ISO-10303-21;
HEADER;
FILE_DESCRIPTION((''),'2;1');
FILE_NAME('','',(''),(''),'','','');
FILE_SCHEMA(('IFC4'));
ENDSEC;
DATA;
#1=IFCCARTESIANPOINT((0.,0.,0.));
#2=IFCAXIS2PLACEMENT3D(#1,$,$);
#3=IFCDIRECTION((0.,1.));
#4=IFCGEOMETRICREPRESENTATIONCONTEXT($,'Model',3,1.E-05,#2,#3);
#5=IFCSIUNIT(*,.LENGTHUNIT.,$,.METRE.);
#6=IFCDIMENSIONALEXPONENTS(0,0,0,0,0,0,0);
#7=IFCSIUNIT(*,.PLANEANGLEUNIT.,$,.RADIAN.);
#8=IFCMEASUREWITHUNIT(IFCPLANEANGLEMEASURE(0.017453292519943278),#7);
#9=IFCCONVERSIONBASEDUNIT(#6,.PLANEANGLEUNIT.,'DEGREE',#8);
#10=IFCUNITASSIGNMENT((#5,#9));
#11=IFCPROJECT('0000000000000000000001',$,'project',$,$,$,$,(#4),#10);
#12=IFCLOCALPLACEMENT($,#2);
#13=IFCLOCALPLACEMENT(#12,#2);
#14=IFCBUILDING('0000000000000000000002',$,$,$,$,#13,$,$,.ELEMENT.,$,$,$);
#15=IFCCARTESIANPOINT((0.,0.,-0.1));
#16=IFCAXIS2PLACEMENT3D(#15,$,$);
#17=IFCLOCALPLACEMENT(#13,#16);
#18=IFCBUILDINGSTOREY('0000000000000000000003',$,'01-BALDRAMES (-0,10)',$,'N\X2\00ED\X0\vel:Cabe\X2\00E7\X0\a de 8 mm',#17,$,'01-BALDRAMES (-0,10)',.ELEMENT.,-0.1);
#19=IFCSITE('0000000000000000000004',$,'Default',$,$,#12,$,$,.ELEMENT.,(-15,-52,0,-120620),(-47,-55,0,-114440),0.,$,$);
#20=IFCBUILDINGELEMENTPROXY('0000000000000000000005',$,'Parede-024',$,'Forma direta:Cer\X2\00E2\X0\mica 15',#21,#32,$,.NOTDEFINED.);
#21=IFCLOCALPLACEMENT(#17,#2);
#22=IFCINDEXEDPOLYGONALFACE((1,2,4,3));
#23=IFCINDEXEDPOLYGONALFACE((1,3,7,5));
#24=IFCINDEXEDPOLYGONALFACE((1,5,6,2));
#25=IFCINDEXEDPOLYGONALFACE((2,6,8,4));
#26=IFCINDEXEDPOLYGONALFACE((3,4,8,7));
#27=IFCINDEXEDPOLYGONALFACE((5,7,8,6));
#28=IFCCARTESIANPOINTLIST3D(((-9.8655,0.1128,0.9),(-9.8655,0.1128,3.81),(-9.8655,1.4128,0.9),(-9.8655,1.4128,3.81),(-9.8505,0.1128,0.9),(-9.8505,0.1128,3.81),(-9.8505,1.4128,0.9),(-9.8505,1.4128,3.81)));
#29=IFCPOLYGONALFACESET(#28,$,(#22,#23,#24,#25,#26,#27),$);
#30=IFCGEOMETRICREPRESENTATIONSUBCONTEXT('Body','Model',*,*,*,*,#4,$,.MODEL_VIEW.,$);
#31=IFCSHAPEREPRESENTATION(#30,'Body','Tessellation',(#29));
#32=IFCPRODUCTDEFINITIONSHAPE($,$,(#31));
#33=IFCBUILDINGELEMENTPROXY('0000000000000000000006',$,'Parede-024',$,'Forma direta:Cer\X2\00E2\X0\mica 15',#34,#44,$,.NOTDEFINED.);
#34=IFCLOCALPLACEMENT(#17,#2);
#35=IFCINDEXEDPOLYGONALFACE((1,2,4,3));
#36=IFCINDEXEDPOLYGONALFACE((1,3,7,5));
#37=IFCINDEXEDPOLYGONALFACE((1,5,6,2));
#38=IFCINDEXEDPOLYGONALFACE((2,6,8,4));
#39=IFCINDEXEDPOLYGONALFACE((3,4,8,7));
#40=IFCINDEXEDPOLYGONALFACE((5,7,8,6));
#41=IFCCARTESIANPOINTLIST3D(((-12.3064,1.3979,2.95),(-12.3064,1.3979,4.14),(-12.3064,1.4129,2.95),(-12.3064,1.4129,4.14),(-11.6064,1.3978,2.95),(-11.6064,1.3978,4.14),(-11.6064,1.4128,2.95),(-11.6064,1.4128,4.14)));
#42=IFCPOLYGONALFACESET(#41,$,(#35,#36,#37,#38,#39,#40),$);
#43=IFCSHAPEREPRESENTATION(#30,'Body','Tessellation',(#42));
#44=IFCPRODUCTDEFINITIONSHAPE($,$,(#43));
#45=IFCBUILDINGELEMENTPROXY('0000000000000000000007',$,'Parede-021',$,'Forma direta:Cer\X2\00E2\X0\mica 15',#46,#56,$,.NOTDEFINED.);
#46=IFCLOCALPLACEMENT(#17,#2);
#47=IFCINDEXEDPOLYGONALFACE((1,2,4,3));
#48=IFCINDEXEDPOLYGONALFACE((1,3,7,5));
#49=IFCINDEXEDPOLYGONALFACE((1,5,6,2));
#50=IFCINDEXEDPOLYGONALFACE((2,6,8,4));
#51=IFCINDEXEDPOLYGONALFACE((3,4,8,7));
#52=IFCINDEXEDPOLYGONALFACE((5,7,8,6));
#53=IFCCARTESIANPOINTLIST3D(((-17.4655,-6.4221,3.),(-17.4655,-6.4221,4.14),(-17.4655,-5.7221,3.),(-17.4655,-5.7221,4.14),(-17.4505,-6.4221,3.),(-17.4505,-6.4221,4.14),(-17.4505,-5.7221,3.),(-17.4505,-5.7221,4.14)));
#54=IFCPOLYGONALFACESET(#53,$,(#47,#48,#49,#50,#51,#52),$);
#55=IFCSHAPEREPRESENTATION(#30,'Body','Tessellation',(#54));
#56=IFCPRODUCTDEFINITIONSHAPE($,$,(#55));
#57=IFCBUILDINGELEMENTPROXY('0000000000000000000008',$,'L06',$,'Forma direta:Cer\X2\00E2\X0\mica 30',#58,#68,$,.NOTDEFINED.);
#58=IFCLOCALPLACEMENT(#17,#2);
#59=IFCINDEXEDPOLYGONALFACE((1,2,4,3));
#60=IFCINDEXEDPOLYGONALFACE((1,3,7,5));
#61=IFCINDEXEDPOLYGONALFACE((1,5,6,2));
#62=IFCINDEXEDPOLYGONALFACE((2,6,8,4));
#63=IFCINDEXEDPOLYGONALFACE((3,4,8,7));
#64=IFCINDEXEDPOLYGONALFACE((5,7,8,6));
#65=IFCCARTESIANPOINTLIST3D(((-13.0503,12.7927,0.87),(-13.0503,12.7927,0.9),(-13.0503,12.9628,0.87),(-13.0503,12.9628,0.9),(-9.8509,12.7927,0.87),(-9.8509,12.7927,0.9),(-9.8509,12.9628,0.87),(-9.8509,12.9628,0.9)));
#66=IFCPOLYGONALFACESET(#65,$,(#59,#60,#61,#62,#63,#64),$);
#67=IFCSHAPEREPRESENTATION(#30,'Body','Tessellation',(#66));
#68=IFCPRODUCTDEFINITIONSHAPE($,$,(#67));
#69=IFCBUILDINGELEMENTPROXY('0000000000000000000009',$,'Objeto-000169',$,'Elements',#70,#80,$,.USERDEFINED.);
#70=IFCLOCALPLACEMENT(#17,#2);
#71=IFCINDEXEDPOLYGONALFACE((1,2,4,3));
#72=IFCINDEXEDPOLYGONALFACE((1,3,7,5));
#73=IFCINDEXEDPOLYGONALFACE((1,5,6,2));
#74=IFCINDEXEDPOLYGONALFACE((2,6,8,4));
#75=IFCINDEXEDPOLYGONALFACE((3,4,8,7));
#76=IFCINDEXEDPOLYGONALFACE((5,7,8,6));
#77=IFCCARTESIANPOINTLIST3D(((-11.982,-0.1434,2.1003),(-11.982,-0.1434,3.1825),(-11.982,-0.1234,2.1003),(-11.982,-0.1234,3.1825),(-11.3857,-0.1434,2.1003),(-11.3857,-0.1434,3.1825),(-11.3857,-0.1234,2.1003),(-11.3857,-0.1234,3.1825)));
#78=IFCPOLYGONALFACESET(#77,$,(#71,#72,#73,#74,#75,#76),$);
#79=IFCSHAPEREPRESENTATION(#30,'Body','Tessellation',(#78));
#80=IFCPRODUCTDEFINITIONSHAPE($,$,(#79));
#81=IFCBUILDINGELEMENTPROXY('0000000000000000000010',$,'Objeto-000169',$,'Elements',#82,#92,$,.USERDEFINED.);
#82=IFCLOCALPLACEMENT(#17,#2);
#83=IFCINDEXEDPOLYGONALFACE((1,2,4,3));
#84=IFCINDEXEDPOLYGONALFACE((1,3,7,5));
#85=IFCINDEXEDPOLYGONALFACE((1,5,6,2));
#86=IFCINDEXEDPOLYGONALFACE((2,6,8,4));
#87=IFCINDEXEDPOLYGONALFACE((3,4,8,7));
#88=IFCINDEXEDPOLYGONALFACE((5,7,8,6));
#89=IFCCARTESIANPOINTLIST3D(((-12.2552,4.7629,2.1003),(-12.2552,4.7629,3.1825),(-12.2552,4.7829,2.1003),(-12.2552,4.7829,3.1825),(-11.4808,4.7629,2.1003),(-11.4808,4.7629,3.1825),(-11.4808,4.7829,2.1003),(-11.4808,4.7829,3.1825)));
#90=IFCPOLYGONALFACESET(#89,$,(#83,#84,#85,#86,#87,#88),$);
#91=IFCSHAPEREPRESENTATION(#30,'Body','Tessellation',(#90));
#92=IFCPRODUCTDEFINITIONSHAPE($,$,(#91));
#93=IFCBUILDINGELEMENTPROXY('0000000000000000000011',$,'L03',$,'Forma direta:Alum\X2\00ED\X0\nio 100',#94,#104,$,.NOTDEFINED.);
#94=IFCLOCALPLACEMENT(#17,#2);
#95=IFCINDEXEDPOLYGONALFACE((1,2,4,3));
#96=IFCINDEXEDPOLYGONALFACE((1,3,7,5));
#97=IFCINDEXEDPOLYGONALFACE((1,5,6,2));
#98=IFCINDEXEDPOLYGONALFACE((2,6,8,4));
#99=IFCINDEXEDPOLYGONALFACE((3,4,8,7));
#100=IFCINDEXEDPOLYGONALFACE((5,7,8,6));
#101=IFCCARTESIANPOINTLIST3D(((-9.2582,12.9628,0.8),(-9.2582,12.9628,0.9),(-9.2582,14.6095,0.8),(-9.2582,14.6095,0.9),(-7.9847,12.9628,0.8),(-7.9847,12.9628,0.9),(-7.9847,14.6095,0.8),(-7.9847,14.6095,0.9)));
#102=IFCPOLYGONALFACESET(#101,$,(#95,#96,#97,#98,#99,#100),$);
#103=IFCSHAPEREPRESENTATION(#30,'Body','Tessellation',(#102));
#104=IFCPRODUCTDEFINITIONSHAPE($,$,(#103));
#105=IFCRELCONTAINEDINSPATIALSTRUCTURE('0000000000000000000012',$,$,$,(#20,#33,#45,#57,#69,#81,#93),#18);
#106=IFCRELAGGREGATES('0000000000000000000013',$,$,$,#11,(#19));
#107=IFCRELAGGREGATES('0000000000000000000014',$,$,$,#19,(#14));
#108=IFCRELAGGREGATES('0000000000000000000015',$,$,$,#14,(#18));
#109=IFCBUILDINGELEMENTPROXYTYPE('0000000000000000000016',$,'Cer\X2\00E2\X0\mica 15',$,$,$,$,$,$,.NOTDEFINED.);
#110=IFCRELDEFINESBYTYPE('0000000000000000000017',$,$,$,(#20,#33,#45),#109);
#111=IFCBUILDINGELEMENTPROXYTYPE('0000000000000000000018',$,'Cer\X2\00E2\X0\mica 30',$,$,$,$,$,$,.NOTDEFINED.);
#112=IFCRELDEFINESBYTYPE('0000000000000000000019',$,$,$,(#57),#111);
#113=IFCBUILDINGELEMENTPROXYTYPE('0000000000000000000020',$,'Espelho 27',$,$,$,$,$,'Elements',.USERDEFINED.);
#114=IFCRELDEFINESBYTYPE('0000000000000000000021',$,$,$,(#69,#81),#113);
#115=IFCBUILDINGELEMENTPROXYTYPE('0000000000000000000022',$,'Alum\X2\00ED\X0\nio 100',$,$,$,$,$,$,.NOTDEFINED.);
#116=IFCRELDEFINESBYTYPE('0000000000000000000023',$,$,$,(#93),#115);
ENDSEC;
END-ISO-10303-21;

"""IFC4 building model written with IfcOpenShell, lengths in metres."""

from ifc_helpers import new_model, entity, si_unit, converted_unit, direction, frame, origin, place, context, subcontext, project, spatial, indexed_curve, outline, extrude, type_object, element, save


model = new_model("IFC4")

# Units and contexts
model_context = context("Model", 3, precision=1e-05, world=origin(), true_north=direction((0.0, 1.0)))
body_context = subcontext(model_context, "Body", "Model", "MODEL_VIEW")
ifc_project = project(units=[si_unit("LENGTHUNIT", "METRE"), converted_unit("PLANEANGLEUNIT", "DEGREE", entity("IfcPlaneAngleMeasure", 0.017453292519943278), si_unit("PLANEANGLEUNIT", "RADIAN"), dimensions=[0, 0, 0, 0, 0, 0, 0])], contexts=[model_context])

# Site, building, storey
site_placement = place(None, origin())
site = spatial("IfcSite", under=ifc_project, at=site_placement, Name="Default", CompositionType="ELEMENT", RefLatitude=(-15, -52, 0, -120620), RefLongitude=(-47, -55, 0, -114440), RefElevation=0.0)
building_placement = place(site_placement, origin())
building = spatial("IfcBuilding", under=site, at=building_placement, CompositionType="ELEMENT")
storey_placement = place(building_placement, frame((0.0, 0.0, -0.1)))
storey = spatial("IfcBuildingStorey", under=building, at=storey_placement, Name="01-BALDRAMES (-0,10)", ObjectType="Nível:Cabeça de 8 mm", LongName="01-BALDRAMES (-0,10)", CompositionType="ELEMENT", Elevation=-0.1)

# Building element proxies
building_element_proxy_type_1 = type_object("IfcBuildingElementProxyType", Name="Cerâmica 15", PredefinedType="NOTDEFINED")
proxy_1_placement = place(storey_placement, origin())
element("IfcBuildingElementProxy", 1, at=proxy_1_placement, inside=storey, type_object=building_element_proxy_type_1, Name="Parede-024", ObjectType="Forma direta:Cerâmica 15", PredefinedType="NOTDEFINED", context=body_context, shape_type="SweptSolid", body=[
    extrude(outline(indexed_curve([(-0.0075, -0.65), (0.0075, -0.65), (0.0075, 0.65), (-0.0075, 0.65), (-0.0075, -0.65)], self_intersect=False)), frame((-9.858, 0.7628, 0.9), z_axis=(0.0, 0.0, 1.0), x_axis=(-1.0, 0.000013, 0.0)), (0.0, 0.0, 1.0), 2.91),
])
proxy_2_placement = place(storey_placement, origin())
element("IfcBuildingElementProxy", 2, at=proxy_2_placement, inside=storey, type_object=building_element_proxy_type_1, Name="Parede-024", ObjectType="Forma direta:Cerâmica 15", PredefinedType="NOTDEFINED", context=body_context, shape_type="SweptSolid", body=[
    extrude(outline(indexed_curve([(-0.0075, -0.35), (0.0075, -0.35), (0.0075, 0.35), (-0.0075, 0.35), (-0.0075, -0.35)], self_intersect=False)), frame((-11.9564, 1.4054, 2.95), z_axis=(0.0, 0.0, 1.0), x_axis=(0.000013, 1.0, 0.0)), (0.0, 0.0, 1.0), 1.19),
])
proxy_3_placement = place(storey_placement, origin())
element("IfcBuildingElementProxy", 3, at=proxy_3_placement, inside=storey, type_object=building_element_proxy_type_1, Name="Parede-021", ObjectType="Forma direta:Cerâmica 15", PredefinedType="NOTDEFINED", context=body_context, shape_type="SweptSolid", body=[
    extrude(outline(indexed_curve([(-0.0075, -0.35), (0.0075, -0.35), (0.0075, 0.35), (-0.0075, 0.35), (-0.0075, -0.35)], self_intersect=False)), frame((-17.458, -6.0721, 3.0)), (0.0, 0.0, 1.0), 1.14),
])
building_element_proxy_type_2 = type_object("IfcBuildingElementProxyType", Name="Cerâmica 30", PredefinedType="NOTDEFINED")
proxy_4_placement = place(storey_placement, origin())
element("IfcBuildingElementProxy", 4, at=proxy_4_placement, inside=storey, type_object=building_element_proxy_type_2, Name="L06", ObjectType="Forma direta:Cerâmica 30", PredefinedType="NOTDEFINED", context=body_context, shape_type="SweptSolid", body=[
    extrude(outline(indexed_curve([(-0.0851, -1.5997), (0.0851, -1.5997), (0.0851, 1.5997), (-0.0851, 1.5997), (-0.0851, -1.5997)], self_intersect=False)), frame((-11.4506, 12.8777, 0.87), z_axis=(0.0, 0.0, 1.0), x_axis=(0.000013, 1.0, 0.0)), (0.0, 0.0, 1.0), 0.03),
])
building_element_proxy_type_3 = type_object("IfcBuildingElementProxyType", Name="Espelho 27", ElementType="Elements", PredefinedType="USERDEFINED")
proxy_5_placement = place(storey_placement, origin())
element("IfcBuildingElementProxy", 5, at=proxy_5_placement, inside=storey, type_object=building_element_proxy_type_3, Name="Objeto-000169", ObjectType="Elements", PredefinedType="USERDEFINED", context=body_context, shape_type="SweptSolid", body=[
    extrude(outline(indexed_curve([(-0.2981, -0.01), (0.2981, -0.01), (0.2981, 0.01), (-0.2981, 0.01), (-0.2981, -0.01)], self_intersect=False)), frame((-11.6839, -0.1334, 2.1003), z_axis=(0.0, 0.0, 1.0), x_axis=(-1.0, 0.000013, 0.0)), (0.0, 0.0, 1.0), 1.0822),
])
proxy_6_placement = place(storey_placement, origin())
element("IfcBuildingElementProxy", 6, at=proxy_6_placement, inside=storey, type_object=building_element_proxy_type_3, Name="Objeto-000169", ObjectType="Elements", PredefinedType="USERDEFINED", context=body_context, shape_type="SweptSolid", body=[
    extrude(outline(indexed_curve([(-0.3872, -0.01), (0.3872, -0.01), (0.3872, 0.01), (-0.3872, 0.01), (-0.3872, -0.01)], self_intersect=False)), frame((-11.868, 4.7729, 2.1003)), (0.0, 0.0, 1.0), 1.0822),
])
building_element_proxy_type_4 = type_object("IfcBuildingElementProxyType", Name="Alumínio 100", PredefinedType="NOTDEFINED")
proxy_7_placement = place(storey_placement, origin())
element("IfcBuildingElementProxy", 7, at=proxy_7_placement, inside=storey, type_object=building_element_proxy_type_4, Name="L03", ObjectType="Forma direta:Alumínio 100", PredefinedType="NOTDEFINED", context=body_context, shape_type="SweptSolid", body=[
    extrude(outline(indexed_curve([(-0.6368, -0.8233), (0.6368, -0.8233), (0.6368, 0.8233), (-0.6368, 0.8233), (-0.6368, -0.8233)], self_intersect=False)), frame((-8.6215, 13.7862, 0.8)), (0.0, 0.0, 1.0), 0.1),
])

save(model, "model.ifc")
